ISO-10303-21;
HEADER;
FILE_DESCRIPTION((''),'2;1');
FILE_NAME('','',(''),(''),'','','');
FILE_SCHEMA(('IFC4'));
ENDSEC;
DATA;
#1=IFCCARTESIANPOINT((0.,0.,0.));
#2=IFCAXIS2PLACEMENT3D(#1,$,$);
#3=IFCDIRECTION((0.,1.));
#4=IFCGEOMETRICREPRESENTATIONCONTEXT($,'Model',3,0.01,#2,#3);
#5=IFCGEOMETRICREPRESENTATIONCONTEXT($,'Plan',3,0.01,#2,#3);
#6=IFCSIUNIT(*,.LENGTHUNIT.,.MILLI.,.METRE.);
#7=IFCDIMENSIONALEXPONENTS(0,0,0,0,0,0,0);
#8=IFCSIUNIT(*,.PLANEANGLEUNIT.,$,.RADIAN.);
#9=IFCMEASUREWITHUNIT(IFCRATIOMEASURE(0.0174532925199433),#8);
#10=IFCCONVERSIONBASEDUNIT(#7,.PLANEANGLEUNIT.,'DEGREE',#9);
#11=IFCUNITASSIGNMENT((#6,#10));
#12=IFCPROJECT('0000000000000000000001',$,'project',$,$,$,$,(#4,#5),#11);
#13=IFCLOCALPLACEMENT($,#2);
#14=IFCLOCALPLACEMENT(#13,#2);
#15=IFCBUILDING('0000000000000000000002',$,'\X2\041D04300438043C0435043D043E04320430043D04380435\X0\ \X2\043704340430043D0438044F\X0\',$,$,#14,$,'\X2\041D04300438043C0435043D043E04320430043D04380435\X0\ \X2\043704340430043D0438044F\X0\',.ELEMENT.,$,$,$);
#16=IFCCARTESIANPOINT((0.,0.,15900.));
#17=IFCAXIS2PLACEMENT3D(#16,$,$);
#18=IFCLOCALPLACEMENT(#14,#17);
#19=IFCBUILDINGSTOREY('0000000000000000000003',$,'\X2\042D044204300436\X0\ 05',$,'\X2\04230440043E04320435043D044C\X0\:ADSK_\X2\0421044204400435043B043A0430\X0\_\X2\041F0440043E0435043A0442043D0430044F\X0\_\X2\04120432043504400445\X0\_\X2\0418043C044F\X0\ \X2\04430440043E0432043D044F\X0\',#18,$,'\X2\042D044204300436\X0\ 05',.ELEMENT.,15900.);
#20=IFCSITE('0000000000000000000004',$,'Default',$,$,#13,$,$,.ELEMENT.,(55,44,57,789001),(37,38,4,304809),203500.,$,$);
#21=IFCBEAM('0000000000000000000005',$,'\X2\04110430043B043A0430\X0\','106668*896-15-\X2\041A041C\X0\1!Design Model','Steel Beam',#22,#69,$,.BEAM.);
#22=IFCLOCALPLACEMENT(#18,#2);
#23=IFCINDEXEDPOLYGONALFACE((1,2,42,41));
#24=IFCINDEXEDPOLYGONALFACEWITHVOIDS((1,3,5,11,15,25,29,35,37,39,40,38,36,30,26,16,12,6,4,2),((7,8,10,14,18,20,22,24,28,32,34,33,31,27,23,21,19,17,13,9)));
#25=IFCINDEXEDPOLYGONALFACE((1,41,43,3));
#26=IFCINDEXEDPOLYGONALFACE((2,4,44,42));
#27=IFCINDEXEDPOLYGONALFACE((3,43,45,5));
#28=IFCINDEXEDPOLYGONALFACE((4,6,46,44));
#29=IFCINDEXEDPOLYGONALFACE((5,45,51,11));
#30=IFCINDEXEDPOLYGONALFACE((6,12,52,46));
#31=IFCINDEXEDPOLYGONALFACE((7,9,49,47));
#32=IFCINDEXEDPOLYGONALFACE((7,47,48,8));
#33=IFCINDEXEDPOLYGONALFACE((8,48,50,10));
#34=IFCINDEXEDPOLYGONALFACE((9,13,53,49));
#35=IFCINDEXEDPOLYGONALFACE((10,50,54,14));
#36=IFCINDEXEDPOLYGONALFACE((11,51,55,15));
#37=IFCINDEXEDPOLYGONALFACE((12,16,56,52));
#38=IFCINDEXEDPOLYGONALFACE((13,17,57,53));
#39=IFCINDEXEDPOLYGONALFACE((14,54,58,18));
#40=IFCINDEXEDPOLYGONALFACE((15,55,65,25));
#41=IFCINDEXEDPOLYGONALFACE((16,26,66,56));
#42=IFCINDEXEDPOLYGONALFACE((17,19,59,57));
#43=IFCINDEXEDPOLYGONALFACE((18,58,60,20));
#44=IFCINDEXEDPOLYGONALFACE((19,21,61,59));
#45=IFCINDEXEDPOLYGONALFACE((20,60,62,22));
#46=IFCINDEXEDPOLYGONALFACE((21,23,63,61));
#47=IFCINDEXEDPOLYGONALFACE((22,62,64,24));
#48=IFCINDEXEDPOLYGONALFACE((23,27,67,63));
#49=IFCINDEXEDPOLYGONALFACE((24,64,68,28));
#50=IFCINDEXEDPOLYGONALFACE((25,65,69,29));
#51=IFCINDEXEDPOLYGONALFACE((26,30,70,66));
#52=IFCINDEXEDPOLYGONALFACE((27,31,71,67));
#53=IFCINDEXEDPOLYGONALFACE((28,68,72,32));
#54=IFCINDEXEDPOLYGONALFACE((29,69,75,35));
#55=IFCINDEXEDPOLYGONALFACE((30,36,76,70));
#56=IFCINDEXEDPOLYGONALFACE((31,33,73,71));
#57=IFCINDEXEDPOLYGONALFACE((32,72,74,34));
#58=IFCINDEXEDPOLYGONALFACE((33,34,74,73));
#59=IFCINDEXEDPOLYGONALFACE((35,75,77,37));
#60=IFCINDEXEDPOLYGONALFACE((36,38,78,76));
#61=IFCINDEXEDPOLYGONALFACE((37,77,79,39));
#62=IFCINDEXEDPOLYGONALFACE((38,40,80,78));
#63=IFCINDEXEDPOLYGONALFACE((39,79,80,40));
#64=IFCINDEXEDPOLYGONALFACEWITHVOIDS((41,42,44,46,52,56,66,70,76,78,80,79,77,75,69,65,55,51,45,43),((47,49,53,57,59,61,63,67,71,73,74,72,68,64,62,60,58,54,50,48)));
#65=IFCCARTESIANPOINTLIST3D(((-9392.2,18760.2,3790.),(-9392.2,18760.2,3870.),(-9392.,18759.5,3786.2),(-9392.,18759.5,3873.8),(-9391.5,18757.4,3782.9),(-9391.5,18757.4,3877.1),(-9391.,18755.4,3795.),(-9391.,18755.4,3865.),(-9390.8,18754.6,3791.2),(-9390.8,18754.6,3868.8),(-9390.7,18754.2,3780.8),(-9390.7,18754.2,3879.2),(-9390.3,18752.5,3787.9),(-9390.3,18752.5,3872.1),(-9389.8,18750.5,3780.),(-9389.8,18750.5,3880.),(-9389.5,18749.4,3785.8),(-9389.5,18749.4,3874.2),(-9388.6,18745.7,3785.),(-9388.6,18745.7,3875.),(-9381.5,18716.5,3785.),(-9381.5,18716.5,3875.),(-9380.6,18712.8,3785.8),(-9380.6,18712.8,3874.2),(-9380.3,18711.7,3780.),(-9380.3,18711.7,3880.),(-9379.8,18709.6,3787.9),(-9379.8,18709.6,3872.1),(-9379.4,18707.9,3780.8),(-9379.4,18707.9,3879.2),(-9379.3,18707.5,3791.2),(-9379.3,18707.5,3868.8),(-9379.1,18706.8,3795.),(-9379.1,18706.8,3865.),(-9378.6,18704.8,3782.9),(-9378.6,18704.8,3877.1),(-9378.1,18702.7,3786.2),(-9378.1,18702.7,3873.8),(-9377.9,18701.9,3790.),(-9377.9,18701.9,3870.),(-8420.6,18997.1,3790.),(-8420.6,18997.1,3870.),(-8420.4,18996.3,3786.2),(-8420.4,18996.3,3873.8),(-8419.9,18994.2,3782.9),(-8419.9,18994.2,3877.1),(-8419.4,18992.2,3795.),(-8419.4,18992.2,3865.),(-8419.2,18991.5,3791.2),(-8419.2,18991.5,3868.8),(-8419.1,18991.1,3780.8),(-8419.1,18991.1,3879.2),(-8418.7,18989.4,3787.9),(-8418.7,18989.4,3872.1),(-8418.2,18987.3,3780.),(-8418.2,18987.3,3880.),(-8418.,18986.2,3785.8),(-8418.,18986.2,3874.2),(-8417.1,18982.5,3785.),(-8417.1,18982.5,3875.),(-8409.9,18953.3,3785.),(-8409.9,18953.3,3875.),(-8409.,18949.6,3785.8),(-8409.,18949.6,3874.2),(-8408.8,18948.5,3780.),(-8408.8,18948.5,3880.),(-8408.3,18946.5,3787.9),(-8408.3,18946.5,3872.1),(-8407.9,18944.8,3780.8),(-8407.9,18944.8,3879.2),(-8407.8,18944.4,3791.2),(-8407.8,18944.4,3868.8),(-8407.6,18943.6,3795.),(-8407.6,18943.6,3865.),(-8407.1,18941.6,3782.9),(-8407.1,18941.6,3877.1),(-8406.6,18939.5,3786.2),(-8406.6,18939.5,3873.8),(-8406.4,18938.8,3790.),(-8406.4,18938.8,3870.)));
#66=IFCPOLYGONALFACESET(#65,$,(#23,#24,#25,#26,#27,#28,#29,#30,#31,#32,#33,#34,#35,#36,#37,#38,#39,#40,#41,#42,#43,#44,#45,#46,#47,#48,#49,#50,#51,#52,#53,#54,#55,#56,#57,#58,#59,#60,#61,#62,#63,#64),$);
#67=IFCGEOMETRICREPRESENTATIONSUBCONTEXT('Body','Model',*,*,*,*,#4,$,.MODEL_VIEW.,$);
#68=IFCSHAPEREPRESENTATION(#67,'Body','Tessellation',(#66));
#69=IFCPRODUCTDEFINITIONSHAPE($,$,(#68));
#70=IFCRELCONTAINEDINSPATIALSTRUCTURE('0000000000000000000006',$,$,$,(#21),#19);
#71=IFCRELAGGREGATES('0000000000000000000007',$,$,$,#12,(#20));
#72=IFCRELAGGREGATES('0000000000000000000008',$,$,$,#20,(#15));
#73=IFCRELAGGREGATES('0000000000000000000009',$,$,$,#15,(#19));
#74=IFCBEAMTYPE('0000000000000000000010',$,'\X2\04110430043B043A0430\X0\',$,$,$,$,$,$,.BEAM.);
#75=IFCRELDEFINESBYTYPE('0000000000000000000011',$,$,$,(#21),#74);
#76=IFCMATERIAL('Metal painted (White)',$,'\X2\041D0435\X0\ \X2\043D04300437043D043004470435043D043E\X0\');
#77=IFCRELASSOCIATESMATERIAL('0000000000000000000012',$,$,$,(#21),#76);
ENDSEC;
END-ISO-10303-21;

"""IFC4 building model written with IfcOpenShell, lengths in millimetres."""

from ifc_helpers import new_model, entity, si_unit, converted_unit, direction, frame, origin, place, context, subcontext, project, spatial, indexed_curve, outline, extrude, material, type_object, element, save


model = new_model("IFC4")

# Units and contexts
model_context = context("Model", 3, precision=0.01, world=origin(), true_north=direction((0.0, 1.0)))
plan_context = context("Plan", 3, precision=0.01, world=origin(), true_north=direction((0.0, 1.0)))
body_context = subcontext(model_context, "Body", "Model", "MODEL_VIEW")
ifc_project = project(units=[si_unit("LENGTHUNIT", "METRE", prefix="MILLI"), converted_unit("PLANEANGLEUNIT", "DEGREE", entity("IfcRatioMeasure", 0.0174532925199433), si_unit("PLANEANGLEUNIT", "RADIAN"), dimensions=[0, 0, 0, 0, 0, 0, 0])], contexts=[model_context, plan_context])

# Site, building, storey
site_placement = place(None, origin())
site = spatial("IfcSite", under=ifc_project, at=site_placement, Name="Default", CompositionType="ELEMENT", RefLatitude=(55, 44, 57, 789001), RefLongitude=(37, 38, 4, 304809), RefElevation=203500.0)
building_placement = place(site_placement, origin())
building = spatial("IfcBuilding", under=site, at=building_placement, Name="Наименование здания", LongName="Наименование здания", CompositionType="ELEMENT")
storey_placement = place(building_placement, frame((0.0, 0.0, 15900.0)))
storey = spatial("IfcBuildingStorey", under=building, at=storey_placement, Name="Этаж 05", ObjectType="Уровень:ADSK_Стрелка_Проектная_Вверх_Имя уровня", LongName="Этаж 05", CompositionType="ELEMENT", Elevation=15900.0)

# Beam
ifc_material = material(Name="Metal painted (White)", Category="Не назначено")
beam_type = type_object("IfcBeamType", Name="Балка", PredefinedType="BEAM")
beam_1_placement = place(storey_placement, origin())
element("IfcBeam", 1, at=beam_1_placement, inside=storey, type_object=beam_type, material=ifc_material, Name="Балка", Description="106668*896-15-КМ1!Design Model", ObjectType="Steel Beam", PredefinedType="BEAM", context=body_context, shape_type="SweptSolid", body=[
    extrude(outline(indexed_curve([(9.9, -52.9), (13.8, -52.9), (17.4, -51.4), (20.1, -48.7), (21.6, -45.1), (37.2, 33.4), (37.2, 37.3), (35.7, 40.9), (33.0, 43.6), (29.4, 45.1), (-9.9, 52.9), (-13.8, 52.9), (-17.4, 51.4), (-20.1, 48.7), (-21.6, 45.1), (-37.2, -33.4), (-37.2, -37.3), (-35.7, -40.9), (-33.0, -43.6), (-29.4, -45.1), (9.9, -52.9)], self_intersect=False), holes=[indexed_curve([(-31.3, -29.5), (-17.7, 39.2), (-16.2, 42.8), (-13.4, 45.6), (-9.8, 47.1), (-5.9, 47.1), (23.5, 41.2), (27.1, 39.7), (29.9, 37.0), (31.3, 33.4), (31.3, 29.5), (17.7, -39.2), (16.2, -42.8), (13.4, -45.6), (9.8, -47.1), (5.9, -47.1), (-23.5, -41.2), (-27.1, -39.7), (-29.9, -37.0), (-31.3, -33.4), (-31.3, -29.5)], self_intersect=False)]), frame((-9385.1, 18731.1, 3830.0), z_axis=(0.971552, 0.236826, 0.0), x_axis=(-0.232276, 0.952884, 0.19509)), (0.0, 0.0, 1.0), 1000.0),
])

save(model, "model.ifc")
